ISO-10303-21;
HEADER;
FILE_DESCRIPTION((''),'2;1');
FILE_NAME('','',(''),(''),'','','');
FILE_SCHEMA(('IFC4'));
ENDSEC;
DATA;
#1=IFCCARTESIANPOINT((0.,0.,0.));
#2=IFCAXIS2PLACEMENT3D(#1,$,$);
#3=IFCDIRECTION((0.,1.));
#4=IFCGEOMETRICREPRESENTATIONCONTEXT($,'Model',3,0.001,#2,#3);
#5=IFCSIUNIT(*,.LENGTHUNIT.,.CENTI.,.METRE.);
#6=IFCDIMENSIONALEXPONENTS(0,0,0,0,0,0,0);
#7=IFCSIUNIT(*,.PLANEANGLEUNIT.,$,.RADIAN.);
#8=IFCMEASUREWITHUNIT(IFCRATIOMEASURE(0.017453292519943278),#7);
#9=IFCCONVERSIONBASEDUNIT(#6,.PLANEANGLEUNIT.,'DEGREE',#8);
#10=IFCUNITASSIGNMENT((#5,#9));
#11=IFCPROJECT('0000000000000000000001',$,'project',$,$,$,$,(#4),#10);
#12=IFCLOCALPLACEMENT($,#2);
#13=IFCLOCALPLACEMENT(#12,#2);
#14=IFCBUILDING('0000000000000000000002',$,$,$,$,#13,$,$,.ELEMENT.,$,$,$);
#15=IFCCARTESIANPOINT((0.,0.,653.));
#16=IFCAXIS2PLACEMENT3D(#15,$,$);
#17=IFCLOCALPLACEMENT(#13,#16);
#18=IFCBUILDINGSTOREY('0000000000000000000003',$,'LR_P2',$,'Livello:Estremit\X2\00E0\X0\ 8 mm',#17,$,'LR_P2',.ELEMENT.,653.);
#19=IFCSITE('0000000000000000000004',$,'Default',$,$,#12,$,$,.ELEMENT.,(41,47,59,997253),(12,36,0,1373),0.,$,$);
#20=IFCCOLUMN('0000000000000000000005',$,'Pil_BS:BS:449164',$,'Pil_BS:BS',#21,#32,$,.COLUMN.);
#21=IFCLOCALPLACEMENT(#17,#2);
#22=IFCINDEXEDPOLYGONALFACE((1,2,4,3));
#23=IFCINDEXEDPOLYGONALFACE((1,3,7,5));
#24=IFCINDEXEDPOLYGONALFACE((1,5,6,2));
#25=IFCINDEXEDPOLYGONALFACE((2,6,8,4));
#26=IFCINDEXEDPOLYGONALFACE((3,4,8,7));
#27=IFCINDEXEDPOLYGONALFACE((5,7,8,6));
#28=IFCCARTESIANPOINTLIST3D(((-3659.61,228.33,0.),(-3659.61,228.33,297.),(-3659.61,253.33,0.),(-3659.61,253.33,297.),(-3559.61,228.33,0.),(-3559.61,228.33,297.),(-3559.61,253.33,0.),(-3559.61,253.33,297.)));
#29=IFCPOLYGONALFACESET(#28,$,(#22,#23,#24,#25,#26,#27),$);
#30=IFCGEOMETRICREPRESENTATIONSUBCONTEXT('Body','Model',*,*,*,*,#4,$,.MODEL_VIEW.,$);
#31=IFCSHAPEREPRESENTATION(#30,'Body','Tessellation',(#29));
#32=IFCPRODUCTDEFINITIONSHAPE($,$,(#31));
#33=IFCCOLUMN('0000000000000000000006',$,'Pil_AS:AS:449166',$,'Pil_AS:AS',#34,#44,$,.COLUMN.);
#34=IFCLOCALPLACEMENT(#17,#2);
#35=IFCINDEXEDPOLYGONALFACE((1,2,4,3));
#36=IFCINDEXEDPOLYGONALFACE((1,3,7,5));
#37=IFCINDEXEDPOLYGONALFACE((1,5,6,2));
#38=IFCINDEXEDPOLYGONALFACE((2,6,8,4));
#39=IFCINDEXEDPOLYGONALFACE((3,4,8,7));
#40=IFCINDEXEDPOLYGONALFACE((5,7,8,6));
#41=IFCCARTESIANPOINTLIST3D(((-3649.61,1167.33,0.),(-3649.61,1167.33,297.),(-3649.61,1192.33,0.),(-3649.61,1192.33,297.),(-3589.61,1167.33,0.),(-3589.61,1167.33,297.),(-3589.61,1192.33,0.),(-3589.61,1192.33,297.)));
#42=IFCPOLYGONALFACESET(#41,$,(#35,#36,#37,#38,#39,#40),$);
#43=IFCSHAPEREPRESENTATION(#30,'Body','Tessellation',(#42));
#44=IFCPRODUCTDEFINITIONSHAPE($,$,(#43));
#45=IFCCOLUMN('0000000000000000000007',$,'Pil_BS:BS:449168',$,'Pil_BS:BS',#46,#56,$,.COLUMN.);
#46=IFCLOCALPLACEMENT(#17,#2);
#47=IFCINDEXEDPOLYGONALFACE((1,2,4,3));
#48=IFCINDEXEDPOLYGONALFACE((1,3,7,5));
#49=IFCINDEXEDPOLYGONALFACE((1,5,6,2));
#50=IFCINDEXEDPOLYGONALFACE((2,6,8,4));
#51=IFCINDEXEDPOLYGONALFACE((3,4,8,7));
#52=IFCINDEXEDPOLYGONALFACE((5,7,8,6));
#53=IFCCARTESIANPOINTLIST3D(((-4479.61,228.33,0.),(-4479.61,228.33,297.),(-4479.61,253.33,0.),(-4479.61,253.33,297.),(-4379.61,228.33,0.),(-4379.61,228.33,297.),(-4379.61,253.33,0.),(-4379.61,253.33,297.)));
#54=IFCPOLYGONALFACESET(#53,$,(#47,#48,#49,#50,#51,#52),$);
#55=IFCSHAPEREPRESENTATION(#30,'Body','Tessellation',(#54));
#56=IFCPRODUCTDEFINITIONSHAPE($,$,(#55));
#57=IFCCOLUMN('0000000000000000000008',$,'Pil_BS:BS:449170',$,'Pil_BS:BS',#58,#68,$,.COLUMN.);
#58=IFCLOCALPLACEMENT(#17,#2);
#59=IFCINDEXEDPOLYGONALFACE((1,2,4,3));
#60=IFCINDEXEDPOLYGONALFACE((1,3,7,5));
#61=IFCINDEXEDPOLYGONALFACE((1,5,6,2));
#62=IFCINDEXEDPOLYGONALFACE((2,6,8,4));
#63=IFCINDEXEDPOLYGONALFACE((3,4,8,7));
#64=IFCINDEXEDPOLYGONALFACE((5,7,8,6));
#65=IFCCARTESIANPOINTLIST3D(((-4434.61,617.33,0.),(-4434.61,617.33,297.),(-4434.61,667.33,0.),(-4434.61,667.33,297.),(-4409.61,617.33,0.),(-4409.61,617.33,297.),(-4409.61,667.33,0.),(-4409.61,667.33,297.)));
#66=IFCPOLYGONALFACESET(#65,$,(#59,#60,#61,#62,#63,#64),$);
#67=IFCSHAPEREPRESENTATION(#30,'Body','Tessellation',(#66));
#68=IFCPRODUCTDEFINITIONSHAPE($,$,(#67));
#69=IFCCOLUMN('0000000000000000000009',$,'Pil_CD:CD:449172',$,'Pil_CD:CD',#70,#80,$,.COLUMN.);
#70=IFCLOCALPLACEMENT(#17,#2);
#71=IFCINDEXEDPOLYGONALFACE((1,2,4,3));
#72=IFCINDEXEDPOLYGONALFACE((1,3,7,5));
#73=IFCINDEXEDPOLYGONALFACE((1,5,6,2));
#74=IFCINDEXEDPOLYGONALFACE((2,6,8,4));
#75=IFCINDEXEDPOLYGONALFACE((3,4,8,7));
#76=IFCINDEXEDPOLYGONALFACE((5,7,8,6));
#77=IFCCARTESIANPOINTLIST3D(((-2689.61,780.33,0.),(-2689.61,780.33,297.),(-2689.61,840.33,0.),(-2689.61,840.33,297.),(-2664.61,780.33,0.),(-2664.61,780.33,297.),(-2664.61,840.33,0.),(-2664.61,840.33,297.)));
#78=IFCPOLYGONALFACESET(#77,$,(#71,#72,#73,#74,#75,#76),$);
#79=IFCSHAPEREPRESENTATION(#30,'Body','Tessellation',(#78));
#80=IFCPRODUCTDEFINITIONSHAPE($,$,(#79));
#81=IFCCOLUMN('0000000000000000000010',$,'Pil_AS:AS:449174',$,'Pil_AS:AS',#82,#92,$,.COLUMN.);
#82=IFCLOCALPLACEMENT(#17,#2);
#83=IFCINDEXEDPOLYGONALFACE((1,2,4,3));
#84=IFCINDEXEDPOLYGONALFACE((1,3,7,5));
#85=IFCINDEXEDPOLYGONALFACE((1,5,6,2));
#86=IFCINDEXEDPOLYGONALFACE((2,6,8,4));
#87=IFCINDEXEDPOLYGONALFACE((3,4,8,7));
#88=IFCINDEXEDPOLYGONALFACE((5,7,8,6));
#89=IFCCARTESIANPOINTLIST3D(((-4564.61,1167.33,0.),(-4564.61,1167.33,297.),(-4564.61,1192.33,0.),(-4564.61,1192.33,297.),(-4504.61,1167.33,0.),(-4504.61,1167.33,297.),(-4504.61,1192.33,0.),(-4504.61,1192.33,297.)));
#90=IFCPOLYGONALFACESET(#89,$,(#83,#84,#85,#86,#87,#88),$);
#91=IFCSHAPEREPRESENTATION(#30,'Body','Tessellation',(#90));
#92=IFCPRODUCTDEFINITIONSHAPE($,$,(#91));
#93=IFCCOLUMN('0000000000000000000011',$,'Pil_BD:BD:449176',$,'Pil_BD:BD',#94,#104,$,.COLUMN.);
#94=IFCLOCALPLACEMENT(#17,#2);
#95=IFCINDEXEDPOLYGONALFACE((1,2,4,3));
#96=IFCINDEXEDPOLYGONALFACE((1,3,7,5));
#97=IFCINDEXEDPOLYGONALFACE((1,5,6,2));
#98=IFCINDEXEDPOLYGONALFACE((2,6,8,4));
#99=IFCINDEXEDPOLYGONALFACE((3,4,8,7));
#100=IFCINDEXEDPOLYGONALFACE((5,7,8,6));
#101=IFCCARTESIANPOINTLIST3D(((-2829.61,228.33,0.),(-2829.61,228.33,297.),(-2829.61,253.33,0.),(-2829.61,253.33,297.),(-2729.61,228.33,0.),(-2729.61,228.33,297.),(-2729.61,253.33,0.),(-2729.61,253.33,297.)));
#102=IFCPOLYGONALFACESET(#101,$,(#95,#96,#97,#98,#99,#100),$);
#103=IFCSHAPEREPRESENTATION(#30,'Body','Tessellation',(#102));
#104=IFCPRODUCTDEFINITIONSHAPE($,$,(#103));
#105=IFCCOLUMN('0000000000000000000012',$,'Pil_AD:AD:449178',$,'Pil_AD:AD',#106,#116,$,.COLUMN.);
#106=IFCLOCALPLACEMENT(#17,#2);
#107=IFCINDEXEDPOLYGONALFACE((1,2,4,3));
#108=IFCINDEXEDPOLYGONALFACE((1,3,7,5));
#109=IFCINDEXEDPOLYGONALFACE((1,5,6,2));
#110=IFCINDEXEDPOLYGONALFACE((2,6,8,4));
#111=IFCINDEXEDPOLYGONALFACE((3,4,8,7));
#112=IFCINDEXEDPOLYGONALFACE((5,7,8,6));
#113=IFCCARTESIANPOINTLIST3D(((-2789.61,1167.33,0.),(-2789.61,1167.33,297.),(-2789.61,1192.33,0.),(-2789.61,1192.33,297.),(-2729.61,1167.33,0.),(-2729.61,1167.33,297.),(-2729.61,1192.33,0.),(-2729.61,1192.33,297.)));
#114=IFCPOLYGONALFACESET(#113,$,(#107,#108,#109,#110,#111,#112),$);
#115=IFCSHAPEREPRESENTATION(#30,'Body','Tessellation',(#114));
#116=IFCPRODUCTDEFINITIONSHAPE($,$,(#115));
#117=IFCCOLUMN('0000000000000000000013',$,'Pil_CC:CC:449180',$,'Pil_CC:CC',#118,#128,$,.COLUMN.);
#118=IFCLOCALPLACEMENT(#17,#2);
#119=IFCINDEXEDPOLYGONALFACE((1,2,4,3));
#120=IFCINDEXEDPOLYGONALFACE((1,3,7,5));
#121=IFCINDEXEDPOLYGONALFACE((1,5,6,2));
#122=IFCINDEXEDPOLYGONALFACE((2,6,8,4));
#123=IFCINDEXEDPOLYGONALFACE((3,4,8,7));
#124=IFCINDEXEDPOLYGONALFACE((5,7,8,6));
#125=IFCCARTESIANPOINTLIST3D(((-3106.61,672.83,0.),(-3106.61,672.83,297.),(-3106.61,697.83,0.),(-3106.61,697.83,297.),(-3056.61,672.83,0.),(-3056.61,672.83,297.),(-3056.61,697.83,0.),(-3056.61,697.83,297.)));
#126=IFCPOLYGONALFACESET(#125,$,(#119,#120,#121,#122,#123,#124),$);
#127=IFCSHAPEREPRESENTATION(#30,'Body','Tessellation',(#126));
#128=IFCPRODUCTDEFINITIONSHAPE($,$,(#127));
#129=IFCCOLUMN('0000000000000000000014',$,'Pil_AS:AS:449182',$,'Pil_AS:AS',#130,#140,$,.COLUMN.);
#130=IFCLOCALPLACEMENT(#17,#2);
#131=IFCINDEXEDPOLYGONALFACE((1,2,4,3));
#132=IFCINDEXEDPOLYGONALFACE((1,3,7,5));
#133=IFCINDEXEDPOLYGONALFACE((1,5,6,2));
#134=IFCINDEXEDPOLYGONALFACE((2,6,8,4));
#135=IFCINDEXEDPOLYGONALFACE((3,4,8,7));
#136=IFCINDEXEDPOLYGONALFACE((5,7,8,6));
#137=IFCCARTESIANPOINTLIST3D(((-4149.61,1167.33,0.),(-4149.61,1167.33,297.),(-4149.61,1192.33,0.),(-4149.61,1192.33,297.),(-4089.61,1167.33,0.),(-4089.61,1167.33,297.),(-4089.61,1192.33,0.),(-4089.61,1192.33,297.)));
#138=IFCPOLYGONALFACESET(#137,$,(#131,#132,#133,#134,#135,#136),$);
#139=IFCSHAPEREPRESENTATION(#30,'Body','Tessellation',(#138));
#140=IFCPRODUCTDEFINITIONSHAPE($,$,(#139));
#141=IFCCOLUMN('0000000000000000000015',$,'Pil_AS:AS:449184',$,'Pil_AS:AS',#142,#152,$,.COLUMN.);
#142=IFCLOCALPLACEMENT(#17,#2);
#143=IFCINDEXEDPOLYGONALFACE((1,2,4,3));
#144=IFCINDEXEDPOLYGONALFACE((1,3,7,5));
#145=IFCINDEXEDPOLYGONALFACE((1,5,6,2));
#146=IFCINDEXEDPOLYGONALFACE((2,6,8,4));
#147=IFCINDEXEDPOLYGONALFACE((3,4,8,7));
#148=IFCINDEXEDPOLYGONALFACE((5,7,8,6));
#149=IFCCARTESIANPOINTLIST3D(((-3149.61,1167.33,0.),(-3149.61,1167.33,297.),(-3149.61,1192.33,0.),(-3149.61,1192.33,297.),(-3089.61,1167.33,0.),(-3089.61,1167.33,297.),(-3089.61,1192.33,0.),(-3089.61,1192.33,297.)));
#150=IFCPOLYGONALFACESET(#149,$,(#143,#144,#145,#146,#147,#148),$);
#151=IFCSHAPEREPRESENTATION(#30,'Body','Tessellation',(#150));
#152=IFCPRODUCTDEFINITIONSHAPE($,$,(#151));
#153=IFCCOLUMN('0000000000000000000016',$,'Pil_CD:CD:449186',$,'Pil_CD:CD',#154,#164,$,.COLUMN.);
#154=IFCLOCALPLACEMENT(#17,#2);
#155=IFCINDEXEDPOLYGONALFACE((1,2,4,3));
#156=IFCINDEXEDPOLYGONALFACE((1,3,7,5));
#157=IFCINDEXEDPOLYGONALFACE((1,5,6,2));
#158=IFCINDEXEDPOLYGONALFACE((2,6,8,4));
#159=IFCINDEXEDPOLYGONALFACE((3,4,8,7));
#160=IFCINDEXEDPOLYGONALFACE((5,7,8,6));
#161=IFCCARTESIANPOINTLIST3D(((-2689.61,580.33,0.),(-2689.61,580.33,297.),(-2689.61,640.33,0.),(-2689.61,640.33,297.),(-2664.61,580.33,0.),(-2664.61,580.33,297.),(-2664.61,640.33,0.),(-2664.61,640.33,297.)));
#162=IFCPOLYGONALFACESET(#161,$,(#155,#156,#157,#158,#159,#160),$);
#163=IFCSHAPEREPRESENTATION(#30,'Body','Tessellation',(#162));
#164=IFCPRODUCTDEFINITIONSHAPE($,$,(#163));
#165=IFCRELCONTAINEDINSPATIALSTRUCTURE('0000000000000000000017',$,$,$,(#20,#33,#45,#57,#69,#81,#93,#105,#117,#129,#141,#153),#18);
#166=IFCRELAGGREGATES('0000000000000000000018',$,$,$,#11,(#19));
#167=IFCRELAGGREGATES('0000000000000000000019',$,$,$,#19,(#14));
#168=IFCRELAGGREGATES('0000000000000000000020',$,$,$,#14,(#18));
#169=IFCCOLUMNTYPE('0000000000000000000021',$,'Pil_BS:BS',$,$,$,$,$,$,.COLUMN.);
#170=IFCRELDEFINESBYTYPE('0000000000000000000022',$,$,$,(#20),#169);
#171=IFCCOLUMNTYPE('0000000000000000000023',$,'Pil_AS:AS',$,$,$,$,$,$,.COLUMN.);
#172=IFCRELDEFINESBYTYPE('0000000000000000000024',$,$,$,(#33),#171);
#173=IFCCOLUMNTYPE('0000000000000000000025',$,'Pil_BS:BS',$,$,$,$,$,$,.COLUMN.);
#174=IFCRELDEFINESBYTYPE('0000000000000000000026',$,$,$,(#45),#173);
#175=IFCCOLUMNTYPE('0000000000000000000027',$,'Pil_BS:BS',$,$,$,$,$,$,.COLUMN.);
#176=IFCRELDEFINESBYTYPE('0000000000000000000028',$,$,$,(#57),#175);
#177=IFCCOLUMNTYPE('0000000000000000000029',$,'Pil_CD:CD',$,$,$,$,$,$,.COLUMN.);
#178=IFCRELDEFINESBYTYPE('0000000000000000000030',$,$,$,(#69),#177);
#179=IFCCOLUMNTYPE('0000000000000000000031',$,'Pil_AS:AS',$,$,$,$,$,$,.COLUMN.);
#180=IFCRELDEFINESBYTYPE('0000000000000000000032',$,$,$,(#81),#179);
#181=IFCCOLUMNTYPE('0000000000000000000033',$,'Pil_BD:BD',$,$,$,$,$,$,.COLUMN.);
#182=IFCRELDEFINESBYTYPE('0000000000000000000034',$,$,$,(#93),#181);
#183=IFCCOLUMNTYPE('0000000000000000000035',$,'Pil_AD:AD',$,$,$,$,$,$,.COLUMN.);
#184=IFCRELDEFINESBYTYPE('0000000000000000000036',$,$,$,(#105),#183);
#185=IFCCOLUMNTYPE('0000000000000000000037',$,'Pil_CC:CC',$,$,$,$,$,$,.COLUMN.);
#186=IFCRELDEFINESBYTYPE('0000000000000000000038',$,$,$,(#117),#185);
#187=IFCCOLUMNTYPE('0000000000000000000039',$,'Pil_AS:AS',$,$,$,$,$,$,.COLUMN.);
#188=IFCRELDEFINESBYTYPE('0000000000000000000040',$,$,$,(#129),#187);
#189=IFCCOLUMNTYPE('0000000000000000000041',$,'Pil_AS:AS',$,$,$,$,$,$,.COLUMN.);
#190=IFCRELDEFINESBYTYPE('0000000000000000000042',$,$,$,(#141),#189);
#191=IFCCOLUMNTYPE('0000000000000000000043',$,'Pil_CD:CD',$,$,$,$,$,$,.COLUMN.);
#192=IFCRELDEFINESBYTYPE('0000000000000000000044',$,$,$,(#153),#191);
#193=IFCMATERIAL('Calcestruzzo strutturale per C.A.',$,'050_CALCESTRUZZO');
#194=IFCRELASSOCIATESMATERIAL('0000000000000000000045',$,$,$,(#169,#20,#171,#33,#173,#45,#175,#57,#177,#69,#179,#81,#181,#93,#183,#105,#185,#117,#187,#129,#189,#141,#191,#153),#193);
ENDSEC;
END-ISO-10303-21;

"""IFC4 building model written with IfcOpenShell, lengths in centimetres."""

from ifc_helpers import new_model, entity, si_unit, converted_unit, direction, frame, origin, place, context, subcontext, project, spatial, indexed_curve, outline, extrude, source, transform, mapped, material, type_object, type_shapes, element, save


model = new_model("IFC4")

# Units and contexts
model_context = context("Model", 3, precision=0.001, world=origin(), true_north=direction((0.0, 1.0)))
body_context = subcontext(model_context, "Body", "Model", "MODEL_VIEW")
ifc_project = project(units=[si_unit("LENGTHUNIT", "METRE", prefix="CENTI"), converted_unit("PLANEANGLEUNIT", "DEGREE", entity("IfcRatioMeasure", 0.017453292519943278), si_unit("PLANEANGLEUNIT", "RADIAN"), dimensions=[0, 0, 0, 0, 0, 0, 0])], contexts=[model_context])

# Site, building, storey
site_placement = place(None, origin())
site = spatial("IfcSite", under=ifc_project, at=site_placement, Name="Default", CompositionType="ELEMENT", RefLatitude=(41, 47, 59, 997253), RefLongitude=(12, 36, 0, 1373), RefElevation=0.0)
building_placement = place(site_placement, origin())
building = spatial("IfcBuilding", under=site, at=building_placement, CompositionType="ELEMENT")
storey_placement = place(building_placement, frame((0.0, 0.0, 653.0)))
storey = spatial("IfcBuildingStorey", under=building, at=storey_placement, Name="LR_P2", ObjectType="Livello:Estremità 8 mm", LongName="LR_P2", CompositionType="ELEMENT", Elevation=653.0)

# Columns
ifc_material = material(Name="Calcestruzzo strutturale per C.A.", Category="050_CALCESTRUZZO")
column_type_1 = type_object("IfcColumnType", Name="Pil_BS:BS", PredefinedType="COLUMN", material=ifc_material)
shared_shape_1 = source(origin(), body_context, "Body", "SweptSolid", [
    extrude(outline(indexed_curve([(-12.5, -50.0), (12.5, -50.0), (12.5, 50.0), (-12.5, 50.0), (-12.5, -50.0)], self_intersect=False)), frame((-3609.61, 240.83, 653.0), z_axis=(0.0, 0.0, 1.0), x_axis=(0.0, -1.0, 0.0)), (0.0, 0.0, 1.0), 297.0),
])
type_shapes(column_type_1, [shared_shape_1])
column_1_placement = place(storey_placement, frame((0.0, 0.0, -653.0)))
element("IfcColumn", 1, at=column_1_placement, inside=storey, type_object=column_type_1, material=ifc_material, Name="Pil_BS:BS:449164", ObjectType="Pil_BS:BS", PredefinedType="COLUMN", context=body_context, shape_type="MappedRepresentation", body=[
    mapped(shared_shape_1, transform((0.0, 0.0, 0.0), scale=1.0)),
])
column_type_2 = type_object("IfcColumnType", Name="Pil_AS:AS", PredefinedType="COLUMN", material=ifc_material)
shared_shape_2 = source(origin(), body_context, "Body", "SweptSolid", [
    extrude(outline(indexed_curve([(-12.5, -30.0), (12.5, -30.0), (12.5, 30.0), (-12.5, 30.0), (-12.5, -30.0)], self_intersect=False)), frame((-3619.61, 1179.83, 653.0), z_axis=(0.0, 0.0, 1.0), x_axis=(0.0, -1.0, 0.0)), (0.0, 0.0, 1.0), 297.0),
])
type_shapes(column_type_2, [shared_shape_2])
column_2_placement = place(storey_placement, frame((0.0, 0.0, -653.0)))
element("IfcColumn", 2, at=column_2_placement, inside=storey, type_object=column_type_2, material=ifc_material, Name="Pil_AS:AS:449166", ObjectType="Pil_AS:AS", PredefinedType="COLUMN", context=body_context, shape_type="MappedRepresentation", body=[
    mapped(shared_shape_2, transform((0.0, 0.0, 0.0), scale=1.0)),
])
column_type_3 = type_object("IfcColumnType", Name="Pil_BS:BS", PredefinedType="COLUMN", material=ifc_material)
shared_shape_3 = source(origin(), body_context, "Body", "SweptSolid", [
    extrude(outline(indexed_curve([(-12.5, -50.0), (12.5, -50.0), (12.5, 50.0), (-12.5, 50.0), (-12.5, -50.0)], self_intersect=False)), frame((-4429.61, 240.83, 653.0), z_axis=(0.0, 0.0, 1.0), x_axis=(0.0, -1.0, 0.0)), (0.0, 0.0, 1.0), 297.0),
])
type_shapes(column_type_3, [shared_shape_3])
column_3_placement = place(storey_placement, frame((0.0, 0.0, -653.0)))
element("IfcColumn", 3, at=column_3_placement, inside=storey, type_object=column_type_3, material=ifc_material, Name="Pil_BS:BS:449168", ObjectType="Pil_BS:BS", PredefinedType="COLUMN", context=body_context, shape_type="MappedRepresentation", body=[
    mapped(shared_shape_3, transform((0.0, 0.0, 0.0), scale=1.0)),
])
column_type_4 = type_object("IfcColumnType", Name="Pil_BS:BS", PredefinedType="COLUMN", material=ifc_material)
shared_shape_4 = source(origin(), body_context, "Body", "SweptSolid", [
    extrude(outline(indexed_curve([(-25.0, -12.5), (25.0, -12.5), (25.0, 12.5), (-25.0, 12.5), (-25.0, -12.5)], self_intersect=False)), frame((-4422.11, 642.33, 653.0), z_axis=(0.0, 0.0, 1.0), x_axis=(0.0, -1.0, 0.0)), (0.0, 0.0, 1.0), 297.0),
])
type_shapes(column_type_4, [shared_shape_4])
column_4_placement = place(storey_placement, frame((0.0, 0.0, -653.0)))
element("IfcColumn", 4, at=column_4_placement, inside=storey, type_object=column_type_4, material=ifc_material, Name="Pil_BS:BS:449170", ObjectType="Pil_BS:BS", PredefinedType="COLUMN", context=body_context, shape_type="MappedRepresentation", body=[
    mapped(shared_shape_4, transform((0.0, 0.0, 0.0), scale=1.0)),
])
column_type_5 = type_object("IfcColumnType", Name="Pil_CD:CD", PredefinedType="COLUMN", material=ifc_material)
shared_shape_5 = source(origin(), body_context, "Body", "SweptSolid", [
    extrude(outline(indexed_curve([(-30.0, -12.5), (30.0, -12.5), (30.0, 12.5), (-30.0, 12.5), (-30.0, -12.5)], self_intersect=False)), frame((-2677.11, 810.33, 653.0), z_axis=(0.0, 0.0, 1.0), x_axis=(0.0, -1.0, 0.0)), (0.0, 0.0, 1.0), 297.0),
])
type_shapes(column_type_5, [shared_shape_5])
column_5_placement = place(storey_placement, frame((0.0, 0.0, -653.0)))
element("IfcColumn", 5, at=column_5_placement, inside=storey, type_object=column_type_5, material=ifc_material, Name="Pil_CD:CD:449172", ObjectType="Pil_CD:CD", PredefinedType="COLUMN", context=body_context, shape_type="MappedRepresentation", body=[
    mapped(shared_shape_5, transform((0.0, 0.0, 0.0), scale=1.0)),
])
column_type_6 = type_object("IfcColumnType", Name="Pil_AS:AS", PredefinedType="COLUMN", material=ifc_material)
shared_shape_6 = source(origin(), body_context, "Body", "SweptSolid", [
    extrude(outline(indexed_curve([(-12.5, -30.0), (12.5, -30.0), (12.5, 30.0), (-12.5, 30.0), (-12.5, -30.0)], self_intersect=False)), frame((-4534.61, 1179.83, 653.0), z_axis=(0.0, 0.0, 1.0), x_axis=(0.0, -1.0, 0.0)), (0.0, 0.0, 1.0), 297.0),
])
type_shapes(column_type_6, [shared_shape_6])
column_6_placement = place(storey_placement, frame((0.0, 0.0, -653.0)))
element("IfcColumn", 6, at=column_6_placement, inside=storey, type_object=column_type_6, material=ifc_material, Name="Pil_AS:AS:449174", ObjectType="Pil_AS:AS", PredefinedType="COLUMN", context=body_context, shape_type="MappedRepresentation", body=[
    mapped(shared_shape_6, transform((0.0, 0.0, 0.0), scale=1.0)),
])
column_type_7 = type_object("IfcColumnType", Name="Pil_BD:BD", PredefinedType="COLUMN", material=ifc_material)
shared_shape_7 = source(origin(), body_context, "Body", "SweptSolid", [
    extrude(outline(indexed_curve([(-12.5, -50.0), (12.5, -50.0), (12.5, 50.0), (-12.5, 50.0), (-12.5, -50.0)], self_intersect=False)), frame((-2779.61, 240.83, 653.0), z_axis=(0.0, 0.0, 1.0), x_axis=(0.0, -1.0, 0.0)), (0.0, 0.0, 1.0), 297.0),
])
type_shapes(column_type_7, [shared_shape_7])
column_7_placement = place(storey_placement, frame((0.0, 0.0, -653.0)))
element("IfcColumn", 7, at=column_7_placement, inside=storey, type_object=column_type_7, material=ifc_material, Name="Pil_BD:BD:449176", ObjectType="Pil_BD:BD", PredefinedType="COLUMN", context=body_context, shape_type="MappedRepresentation", body=[
    mapped(shared_shape_7, transform((0.0, 0.0, 0.0), scale=1.0)),
])
column_type_8 = type_object("IfcColumnType", Name="Pil_AD:AD", PredefinedType="COLUMN", material=ifc_material)
shared_shape_8 = source(origin(), body_context, "Body", "SweptSolid", [
    extrude(outline(indexed_curve([(-12.5, -30.0), (12.5, -30.0), (12.5, 30.0), (-12.5, 30.0), (-12.5, -30.0)], self_intersect=False)), frame((-2759.61, 1179.83, 653.0), z_axis=(0.0, 0.0, 1.0), x_axis=(0.0, -1.0, 0.0)), (0.0, 0.0, 1.0), 297.0),
])
type_shapes(column_type_8, [shared_shape_8])
column_8_placement = place(storey_placement, frame((0.0, 0.0, -653.0)))
element("IfcColumn", 8, at=column_8_placement, inside=storey, type_object=column_type_8, material=ifc_material, Name="Pil_AD:AD:449178", ObjectType="Pil_AD:AD", PredefinedType="COLUMN", context=body_context, shape_type="MappedRepresentation", body=[
    mapped(shared_shape_8, transform((0.0, 0.0, 0.0), scale=1.0)),
])
column_type_9 = type_object("IfcColumnType", Name="Pil_CC:CC", PredefinedType="COLUMN", material=ifc_material)
shared_shape_9 = source(origin(), body_context, "Body", "SweptSolid", [
    extrude(outline(indexed_curve([(-12.5, -25.0), (12.5, -25.0), (12.5, 25.0), (-12.5, 25.0), (-12.5, -25.0)], self_intersect=False)), frame((-3081.61, 685.33, 653.0), z_axis=(0.0, 0.0, 1.0), x_axis=(0.0, -1.0, 0.0)), (0.0, 0.0, 1.0), 297.0),
])
type_shapes(column_type_9, [shared_shape_9])
column_9_placement = place(storey_placement, frame((0.0, 0.0, -653.0)))
element("IfcColumn", 9, at=column_9_placement, inside=storey, type_object=column_type_9, material=ifc_material, Name="Pil_CC:CC:449180", ObjectType="Pil_CC:CC", PredefinedType="COLUMN", context=body_context, shape_type="MappedRepresentation", body=[
    mapped(shared_shape_9, transform((0.0, 0.0, 0.0), scale=1.0)),
])
column_type_10 = type_object("IfcColumnType", Name="Pil_AS:AS", PredefinedType="COLUMN", material=ifc_material)
shared_shape_10 = source(origin(), body_context, "Body", "SweptSolid", [
    extrude(outline(indexed_curve([(-12.5, -30.0), (12.5, -30.0), (12.5, 30.0), (-12.5, 30.0), (-12.5, -30.0)], self_intersect=False)), frame((-4119.61, 1179.83, 653.0), z_axis=(0.0, 0.0, 1.0), x_axis=(0.0, -1.0, 0.0)), (0.0, 0.0, 1.0), 297.0),
])
type_shapes(column_type_10, [shared_shape_10])
column_10_placement = place(storey_placement, frame((0.0, 0.0, -653.0)))
element("IfcColumn", 10, at=column_10_placement, inside=storey, type_object=column_type_10, material=ifc_material, Name="Pil_AS:AS:449182", ObjectType="Pil_AS:AS", PredefinedType="COLUMN", context=body_context, shape_type="MappedRepresentation", body=[
    mapped(shared_shape_10, transform((0.0, 0.0, 0.0), scale=1.0)),
])
column_type_11 = type_object("IfcColumnType", Name="Pil_AS:AS", PredefinedType="COLUMN", material=ifc_material)
shared_shape_11 = source(origin(), body_context, "Body", "SweptSolid", [
    extrude(outline(indexed_curve([(-12.5, -30.0), (12.5, -30.0), (12.5, 30.0), (-12.5, 30.0), (-12.5, -30.0)], self_intersect=False)), frame((-3119.61, 1179.83, 653.0), z_axis=(0.0, 0.0, 1.0), x_axis=(0.0, -1.0, 0.0)), (0.0, 0.0, 1.0), 297.0),
])
type_shapes(column_type_11, [shared_shape_11])
column_11_placement = place(storey_placement, frame((0.0, 0.0, -653.0)))
element("IfcColumn", 11, at=column_11_placement, inside=storey, type_object=column_type_11, material=ifc_material, Name="Pil_AS:AS:449184", ObjectType="Pil_AS:AS", PredefinedType="COLUMN", context=body_context, shape_type="MappedRepresentation", body=[
    mapped(shared_shape_11, transform((0.0, 0.0, 0.0), scale=1.0)),
])
column_type_12 = type_object("IfcColumnType", Name="Pil_CD:CD", PredefinedType="COLUMN", material=ifc_material)
shared_shape_12 = source(origin(), body_context, "Body", "SweptSolid", [
    extrude(outline(indexed_curve([(-30.0, -12.5), (30.0, -12.5), (30.0, 12.5), (-30.0, 12.5), (-30.0, -12.5)], self_intersect=False)), frame((-2677.11, 610.33, 653.0), z_axis=(0.0, 0.0, 1.0), x_axis=(0.0, -1.0, 0.0)), (0.0, 0.0, 1.0), 297.0),
])
type_shapes(column_type_12, [shared_shape_12])
column_12_placement = place(storey_placement, frame((0.0, 0.0, -653.0)))
element("IfcColumn", 12, at=column_12_placement, inside=storey, type_object=column_type_12, material=ifc_material, Name="Pil_CD:CD:449186", ObjectType="Pil_CD:CD", PredefinedType="COLUMN", context=body_context, shape_type="MappedRepresentation", body=[
    mapped(shared_shape_12, transform((0.0, 0.0, 0.0), scale=1.0)),
])

save(model, "model.ifc")
